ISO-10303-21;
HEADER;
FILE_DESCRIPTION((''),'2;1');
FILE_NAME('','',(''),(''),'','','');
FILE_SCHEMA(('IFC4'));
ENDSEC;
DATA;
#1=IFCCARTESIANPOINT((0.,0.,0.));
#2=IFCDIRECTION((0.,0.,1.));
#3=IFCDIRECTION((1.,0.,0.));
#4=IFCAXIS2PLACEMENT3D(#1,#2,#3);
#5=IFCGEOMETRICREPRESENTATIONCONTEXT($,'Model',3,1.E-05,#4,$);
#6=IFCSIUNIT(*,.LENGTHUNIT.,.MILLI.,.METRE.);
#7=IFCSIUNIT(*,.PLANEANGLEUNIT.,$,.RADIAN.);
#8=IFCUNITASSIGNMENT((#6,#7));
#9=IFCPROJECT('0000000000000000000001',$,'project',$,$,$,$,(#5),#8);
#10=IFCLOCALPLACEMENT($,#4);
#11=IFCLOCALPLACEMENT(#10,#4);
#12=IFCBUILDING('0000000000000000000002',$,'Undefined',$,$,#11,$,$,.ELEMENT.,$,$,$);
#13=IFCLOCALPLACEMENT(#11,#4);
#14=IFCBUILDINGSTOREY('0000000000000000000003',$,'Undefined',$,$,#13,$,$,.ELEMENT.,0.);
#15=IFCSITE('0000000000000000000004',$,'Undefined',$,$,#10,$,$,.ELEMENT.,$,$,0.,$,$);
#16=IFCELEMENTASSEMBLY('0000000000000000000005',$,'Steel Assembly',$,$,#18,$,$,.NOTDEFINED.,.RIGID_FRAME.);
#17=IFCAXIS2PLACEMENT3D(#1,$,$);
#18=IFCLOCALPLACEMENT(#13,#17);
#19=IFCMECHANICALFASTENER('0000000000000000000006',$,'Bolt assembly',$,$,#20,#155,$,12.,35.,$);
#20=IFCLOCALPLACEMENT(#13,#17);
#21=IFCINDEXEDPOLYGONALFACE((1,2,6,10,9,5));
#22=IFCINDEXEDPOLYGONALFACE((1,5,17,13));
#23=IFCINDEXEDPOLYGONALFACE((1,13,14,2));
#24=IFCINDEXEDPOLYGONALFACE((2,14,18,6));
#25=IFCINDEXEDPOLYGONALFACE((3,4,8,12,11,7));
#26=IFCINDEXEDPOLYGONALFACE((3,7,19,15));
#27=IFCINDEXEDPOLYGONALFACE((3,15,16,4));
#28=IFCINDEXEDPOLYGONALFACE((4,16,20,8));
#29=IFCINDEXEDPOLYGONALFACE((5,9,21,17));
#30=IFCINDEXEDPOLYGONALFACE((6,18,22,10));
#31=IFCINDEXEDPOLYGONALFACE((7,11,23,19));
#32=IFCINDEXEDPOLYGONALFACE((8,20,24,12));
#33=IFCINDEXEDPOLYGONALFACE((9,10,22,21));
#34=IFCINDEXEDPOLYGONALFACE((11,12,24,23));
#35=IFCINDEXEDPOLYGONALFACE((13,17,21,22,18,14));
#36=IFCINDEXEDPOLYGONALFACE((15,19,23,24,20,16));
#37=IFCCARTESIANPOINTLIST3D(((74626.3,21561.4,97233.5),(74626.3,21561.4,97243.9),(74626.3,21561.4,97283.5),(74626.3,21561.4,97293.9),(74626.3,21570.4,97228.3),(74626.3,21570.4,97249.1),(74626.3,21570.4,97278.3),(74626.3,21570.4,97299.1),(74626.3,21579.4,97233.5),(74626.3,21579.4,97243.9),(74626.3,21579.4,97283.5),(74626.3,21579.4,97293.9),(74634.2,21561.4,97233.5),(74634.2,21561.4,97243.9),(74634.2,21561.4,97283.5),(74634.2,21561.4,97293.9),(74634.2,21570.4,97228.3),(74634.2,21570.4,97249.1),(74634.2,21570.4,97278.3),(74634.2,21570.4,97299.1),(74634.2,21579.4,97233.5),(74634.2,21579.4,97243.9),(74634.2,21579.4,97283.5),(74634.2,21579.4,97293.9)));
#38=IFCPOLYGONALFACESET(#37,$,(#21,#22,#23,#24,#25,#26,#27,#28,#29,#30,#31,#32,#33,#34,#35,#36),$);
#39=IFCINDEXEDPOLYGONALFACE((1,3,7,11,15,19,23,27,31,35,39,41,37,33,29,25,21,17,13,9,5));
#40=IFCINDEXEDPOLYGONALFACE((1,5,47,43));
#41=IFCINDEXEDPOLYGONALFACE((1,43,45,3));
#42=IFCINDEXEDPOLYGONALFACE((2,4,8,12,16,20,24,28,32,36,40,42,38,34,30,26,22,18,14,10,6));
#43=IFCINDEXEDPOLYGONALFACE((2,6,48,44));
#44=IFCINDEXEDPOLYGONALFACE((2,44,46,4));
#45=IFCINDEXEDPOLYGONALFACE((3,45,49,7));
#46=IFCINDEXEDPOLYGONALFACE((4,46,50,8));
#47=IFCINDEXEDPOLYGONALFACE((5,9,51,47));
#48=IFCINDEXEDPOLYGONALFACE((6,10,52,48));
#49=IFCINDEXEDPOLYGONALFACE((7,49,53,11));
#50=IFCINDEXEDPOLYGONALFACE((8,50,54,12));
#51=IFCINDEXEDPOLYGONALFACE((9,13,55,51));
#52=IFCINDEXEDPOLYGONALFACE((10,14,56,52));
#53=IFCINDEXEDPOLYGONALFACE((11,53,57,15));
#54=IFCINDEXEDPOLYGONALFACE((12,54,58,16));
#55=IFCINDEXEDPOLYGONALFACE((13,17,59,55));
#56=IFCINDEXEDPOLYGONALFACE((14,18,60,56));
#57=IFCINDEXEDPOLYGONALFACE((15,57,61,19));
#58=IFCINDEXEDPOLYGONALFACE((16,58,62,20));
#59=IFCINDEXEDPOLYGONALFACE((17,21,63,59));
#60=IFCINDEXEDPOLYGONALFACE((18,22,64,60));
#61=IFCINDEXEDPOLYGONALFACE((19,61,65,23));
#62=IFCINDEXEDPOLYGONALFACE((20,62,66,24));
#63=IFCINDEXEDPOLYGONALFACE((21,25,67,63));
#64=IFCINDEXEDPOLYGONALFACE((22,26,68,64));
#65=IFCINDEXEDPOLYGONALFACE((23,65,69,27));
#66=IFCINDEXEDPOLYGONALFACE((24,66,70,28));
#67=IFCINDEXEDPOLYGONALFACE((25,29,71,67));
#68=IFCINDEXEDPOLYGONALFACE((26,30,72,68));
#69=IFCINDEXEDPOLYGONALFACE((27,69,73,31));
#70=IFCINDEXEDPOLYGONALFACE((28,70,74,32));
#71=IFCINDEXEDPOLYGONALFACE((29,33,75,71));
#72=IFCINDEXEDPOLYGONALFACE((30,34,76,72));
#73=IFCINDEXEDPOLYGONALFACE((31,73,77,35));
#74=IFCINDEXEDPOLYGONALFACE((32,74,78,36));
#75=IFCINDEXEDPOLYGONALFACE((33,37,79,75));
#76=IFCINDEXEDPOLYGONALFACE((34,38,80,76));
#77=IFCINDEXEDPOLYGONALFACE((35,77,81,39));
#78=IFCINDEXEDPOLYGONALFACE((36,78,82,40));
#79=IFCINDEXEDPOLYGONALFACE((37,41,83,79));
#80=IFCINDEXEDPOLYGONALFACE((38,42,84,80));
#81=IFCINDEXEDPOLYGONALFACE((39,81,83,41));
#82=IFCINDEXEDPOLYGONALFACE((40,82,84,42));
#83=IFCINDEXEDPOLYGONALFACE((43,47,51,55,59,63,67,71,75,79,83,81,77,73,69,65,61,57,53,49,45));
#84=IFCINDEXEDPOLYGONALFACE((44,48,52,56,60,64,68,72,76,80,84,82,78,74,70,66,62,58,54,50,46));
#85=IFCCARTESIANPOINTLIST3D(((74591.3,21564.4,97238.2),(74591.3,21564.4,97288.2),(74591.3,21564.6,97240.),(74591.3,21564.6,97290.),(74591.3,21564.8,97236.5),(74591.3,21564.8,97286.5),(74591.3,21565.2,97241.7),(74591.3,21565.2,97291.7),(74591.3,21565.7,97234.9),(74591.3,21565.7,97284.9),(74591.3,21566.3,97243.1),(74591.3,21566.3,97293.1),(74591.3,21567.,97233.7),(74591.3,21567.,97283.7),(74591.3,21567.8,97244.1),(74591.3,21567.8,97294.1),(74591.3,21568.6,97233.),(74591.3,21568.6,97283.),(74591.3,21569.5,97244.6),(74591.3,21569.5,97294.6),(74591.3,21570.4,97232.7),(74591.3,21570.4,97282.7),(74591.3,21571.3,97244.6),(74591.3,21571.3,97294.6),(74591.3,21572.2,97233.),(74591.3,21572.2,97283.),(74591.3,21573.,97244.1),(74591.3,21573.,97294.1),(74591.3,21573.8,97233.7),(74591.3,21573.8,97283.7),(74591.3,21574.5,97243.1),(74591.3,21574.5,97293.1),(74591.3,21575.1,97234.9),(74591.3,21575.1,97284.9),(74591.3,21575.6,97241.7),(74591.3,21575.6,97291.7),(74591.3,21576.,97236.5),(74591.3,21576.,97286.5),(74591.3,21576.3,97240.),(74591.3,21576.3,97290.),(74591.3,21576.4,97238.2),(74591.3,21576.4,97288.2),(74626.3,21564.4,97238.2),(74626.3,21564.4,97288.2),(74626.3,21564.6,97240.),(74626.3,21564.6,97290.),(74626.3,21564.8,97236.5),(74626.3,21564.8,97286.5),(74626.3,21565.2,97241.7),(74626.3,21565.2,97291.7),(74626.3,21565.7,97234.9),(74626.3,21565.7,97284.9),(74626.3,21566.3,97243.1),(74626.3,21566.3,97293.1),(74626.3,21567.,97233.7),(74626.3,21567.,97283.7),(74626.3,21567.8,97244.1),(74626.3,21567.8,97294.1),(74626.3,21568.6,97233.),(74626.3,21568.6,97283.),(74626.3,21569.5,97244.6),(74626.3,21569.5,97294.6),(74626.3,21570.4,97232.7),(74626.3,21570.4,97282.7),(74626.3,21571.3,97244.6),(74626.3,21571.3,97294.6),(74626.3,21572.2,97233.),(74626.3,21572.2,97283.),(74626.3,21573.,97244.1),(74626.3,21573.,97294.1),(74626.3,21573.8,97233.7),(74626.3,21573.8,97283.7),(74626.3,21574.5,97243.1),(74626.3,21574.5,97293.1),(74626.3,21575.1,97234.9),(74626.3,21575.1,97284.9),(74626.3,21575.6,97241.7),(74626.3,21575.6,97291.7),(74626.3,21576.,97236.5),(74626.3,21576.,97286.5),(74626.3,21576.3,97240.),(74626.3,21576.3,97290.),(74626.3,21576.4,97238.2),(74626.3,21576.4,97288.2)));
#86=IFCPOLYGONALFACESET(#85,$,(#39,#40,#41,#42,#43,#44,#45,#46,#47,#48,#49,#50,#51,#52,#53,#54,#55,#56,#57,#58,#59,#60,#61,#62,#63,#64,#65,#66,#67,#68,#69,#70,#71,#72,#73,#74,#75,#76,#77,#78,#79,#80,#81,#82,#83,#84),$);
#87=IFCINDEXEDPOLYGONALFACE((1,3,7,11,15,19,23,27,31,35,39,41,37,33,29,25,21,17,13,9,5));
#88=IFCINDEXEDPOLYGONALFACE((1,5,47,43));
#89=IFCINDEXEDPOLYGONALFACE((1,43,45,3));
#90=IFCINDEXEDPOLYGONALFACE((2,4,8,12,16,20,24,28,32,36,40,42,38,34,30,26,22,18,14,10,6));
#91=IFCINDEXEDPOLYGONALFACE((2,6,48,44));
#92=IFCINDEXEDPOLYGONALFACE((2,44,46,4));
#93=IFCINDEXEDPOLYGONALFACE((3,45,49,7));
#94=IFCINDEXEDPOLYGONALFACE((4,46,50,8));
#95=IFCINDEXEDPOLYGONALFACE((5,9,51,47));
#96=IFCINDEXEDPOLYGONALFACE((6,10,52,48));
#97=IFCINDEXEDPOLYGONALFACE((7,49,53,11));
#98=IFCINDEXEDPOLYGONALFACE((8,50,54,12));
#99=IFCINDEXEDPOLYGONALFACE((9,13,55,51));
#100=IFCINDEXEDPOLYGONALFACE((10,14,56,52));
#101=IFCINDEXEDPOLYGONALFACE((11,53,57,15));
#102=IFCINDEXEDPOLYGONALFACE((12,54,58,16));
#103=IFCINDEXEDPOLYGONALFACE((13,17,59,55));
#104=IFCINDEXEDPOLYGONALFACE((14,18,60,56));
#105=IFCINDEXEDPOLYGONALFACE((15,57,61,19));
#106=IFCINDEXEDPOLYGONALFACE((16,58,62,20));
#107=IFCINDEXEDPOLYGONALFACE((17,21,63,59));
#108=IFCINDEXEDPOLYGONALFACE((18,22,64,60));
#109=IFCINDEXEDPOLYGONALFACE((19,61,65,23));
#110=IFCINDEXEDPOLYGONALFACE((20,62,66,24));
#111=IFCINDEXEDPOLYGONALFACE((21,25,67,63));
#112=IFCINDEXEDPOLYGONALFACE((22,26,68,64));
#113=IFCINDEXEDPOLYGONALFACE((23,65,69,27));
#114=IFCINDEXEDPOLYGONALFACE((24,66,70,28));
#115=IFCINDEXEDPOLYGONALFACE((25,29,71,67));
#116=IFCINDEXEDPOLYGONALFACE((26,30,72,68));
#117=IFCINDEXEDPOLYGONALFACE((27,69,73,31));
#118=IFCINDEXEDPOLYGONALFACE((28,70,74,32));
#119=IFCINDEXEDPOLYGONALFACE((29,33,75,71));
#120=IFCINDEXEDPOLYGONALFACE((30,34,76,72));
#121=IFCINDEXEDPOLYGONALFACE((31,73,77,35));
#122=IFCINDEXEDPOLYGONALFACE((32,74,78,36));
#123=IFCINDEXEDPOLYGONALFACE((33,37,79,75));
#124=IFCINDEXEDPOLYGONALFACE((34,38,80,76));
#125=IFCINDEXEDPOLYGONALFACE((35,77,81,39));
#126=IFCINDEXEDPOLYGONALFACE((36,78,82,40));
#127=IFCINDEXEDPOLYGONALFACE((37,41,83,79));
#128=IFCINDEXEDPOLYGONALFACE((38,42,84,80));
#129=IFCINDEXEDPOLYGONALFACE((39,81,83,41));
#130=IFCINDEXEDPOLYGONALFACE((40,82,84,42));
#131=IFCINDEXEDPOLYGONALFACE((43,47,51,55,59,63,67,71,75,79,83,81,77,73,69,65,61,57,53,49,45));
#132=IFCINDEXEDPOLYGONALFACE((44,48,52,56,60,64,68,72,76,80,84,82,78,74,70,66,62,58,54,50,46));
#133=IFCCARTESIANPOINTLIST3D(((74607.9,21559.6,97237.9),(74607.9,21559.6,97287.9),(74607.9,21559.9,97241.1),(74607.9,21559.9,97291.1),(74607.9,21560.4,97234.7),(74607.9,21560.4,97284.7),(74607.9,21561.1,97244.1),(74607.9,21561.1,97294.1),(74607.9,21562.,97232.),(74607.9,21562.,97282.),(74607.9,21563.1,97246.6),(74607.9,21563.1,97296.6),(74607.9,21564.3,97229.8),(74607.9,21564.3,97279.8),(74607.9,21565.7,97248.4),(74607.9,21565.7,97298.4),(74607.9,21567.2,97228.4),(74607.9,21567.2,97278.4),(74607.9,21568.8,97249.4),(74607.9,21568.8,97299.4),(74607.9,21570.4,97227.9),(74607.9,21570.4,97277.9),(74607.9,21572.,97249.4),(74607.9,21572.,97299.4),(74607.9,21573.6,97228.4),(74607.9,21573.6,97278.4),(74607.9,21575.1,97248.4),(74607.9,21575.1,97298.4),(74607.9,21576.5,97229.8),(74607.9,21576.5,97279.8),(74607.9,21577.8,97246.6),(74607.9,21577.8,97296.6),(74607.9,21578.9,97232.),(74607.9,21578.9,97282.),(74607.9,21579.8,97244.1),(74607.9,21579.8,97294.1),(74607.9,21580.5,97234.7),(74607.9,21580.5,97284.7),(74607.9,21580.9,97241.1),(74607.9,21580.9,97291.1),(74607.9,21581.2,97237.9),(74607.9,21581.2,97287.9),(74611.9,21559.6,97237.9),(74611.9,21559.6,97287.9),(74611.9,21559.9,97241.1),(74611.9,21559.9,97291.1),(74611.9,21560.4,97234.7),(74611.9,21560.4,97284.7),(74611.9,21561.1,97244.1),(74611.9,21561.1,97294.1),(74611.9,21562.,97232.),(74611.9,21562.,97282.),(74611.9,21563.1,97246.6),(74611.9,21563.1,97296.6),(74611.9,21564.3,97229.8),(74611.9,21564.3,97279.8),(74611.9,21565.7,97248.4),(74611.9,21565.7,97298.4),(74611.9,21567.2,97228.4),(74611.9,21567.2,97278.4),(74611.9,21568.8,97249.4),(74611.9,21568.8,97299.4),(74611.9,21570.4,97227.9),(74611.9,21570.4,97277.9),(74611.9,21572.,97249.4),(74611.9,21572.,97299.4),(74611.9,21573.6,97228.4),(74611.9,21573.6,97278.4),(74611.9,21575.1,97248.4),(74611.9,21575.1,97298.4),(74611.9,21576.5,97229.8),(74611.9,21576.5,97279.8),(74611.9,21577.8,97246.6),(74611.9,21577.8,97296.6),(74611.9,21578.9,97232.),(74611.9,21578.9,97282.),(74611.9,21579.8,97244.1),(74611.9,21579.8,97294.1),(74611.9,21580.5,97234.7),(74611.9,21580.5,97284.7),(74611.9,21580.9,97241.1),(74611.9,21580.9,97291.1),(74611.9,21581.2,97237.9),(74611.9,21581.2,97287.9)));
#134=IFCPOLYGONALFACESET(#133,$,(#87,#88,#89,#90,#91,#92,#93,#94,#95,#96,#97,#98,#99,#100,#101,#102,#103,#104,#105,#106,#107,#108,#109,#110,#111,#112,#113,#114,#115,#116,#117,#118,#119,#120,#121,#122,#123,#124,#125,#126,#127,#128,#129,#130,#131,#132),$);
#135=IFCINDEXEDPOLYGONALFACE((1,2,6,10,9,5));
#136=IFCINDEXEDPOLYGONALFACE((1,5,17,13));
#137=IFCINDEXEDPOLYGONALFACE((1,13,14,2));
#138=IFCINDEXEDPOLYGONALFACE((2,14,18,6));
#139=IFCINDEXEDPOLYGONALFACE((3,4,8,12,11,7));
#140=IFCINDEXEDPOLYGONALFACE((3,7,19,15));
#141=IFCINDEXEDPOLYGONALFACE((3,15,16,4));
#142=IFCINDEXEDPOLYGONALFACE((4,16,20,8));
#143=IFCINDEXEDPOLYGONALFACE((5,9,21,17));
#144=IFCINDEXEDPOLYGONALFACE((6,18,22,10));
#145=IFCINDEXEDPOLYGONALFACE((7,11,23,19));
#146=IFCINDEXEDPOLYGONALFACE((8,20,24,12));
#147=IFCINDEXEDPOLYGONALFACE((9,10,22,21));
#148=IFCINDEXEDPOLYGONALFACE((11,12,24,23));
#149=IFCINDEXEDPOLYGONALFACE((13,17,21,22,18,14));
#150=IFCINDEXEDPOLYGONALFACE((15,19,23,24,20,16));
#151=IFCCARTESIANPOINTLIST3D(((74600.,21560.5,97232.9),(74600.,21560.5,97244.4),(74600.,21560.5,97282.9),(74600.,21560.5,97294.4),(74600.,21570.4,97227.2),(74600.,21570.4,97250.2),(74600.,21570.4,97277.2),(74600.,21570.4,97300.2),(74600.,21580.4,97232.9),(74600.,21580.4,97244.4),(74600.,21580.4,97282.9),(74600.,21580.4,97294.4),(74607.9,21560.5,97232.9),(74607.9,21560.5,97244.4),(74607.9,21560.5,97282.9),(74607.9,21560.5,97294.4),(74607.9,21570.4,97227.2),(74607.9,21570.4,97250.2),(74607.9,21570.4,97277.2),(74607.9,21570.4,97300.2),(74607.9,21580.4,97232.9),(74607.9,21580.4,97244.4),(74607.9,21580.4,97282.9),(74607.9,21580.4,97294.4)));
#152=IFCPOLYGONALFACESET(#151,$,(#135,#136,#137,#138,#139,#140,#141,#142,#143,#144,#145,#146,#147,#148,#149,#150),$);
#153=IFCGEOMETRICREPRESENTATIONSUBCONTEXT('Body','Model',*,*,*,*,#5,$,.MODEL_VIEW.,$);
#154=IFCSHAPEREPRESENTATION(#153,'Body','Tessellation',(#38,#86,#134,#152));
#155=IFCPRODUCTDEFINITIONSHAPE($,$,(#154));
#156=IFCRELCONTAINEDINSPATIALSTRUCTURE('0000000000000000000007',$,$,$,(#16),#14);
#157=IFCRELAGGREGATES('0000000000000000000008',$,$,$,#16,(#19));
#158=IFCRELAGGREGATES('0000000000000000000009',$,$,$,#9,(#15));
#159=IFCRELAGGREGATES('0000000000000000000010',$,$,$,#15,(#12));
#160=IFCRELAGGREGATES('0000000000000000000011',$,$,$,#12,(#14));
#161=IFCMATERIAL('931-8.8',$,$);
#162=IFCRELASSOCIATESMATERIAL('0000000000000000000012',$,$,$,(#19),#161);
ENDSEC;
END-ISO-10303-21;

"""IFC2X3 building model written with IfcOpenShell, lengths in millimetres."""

from ifc_helpers import new_model, si_unit, frame, origin_with_axes, origin_2d_with_axis, place, context, subcontext, project, spatial, polyline, circle, outline, extrude, source, transform, mapped, material, element, aggregate, save


model = new_model("IFC2X3")

# Units and contexts
model_context = context("Model", 3, precision=1e-05, world=origin_with_axes())
body_context = subcontext(model_context, "Body", "Model", "MODEL_VIEW")
ifc_project = project(units=[si_unit("LENGTHUNIT", "METRE", prefix="MILLI"), si_unit("PLANEANGLEUNIT", "RADIAN")], contexts=[model_context])

# Site, building, storey
site_placement = place(None, origin_with_axes())
site = spatial("IfcSite", under=ifc_project, at=site_placement, Name="Undefined", CompositionType="ELEMENT", RefElevation=0.0)
building_placement = place(site_placement, origin_with_axes())
building = spatial("IfcBuilding", under=site, at=building_placement, Name="Undefined", CompositionType="ELEMENT")
storey_placement = place(building_placement, origin_with_axes())
storey = spatial("IfcBuildingStorey", under=building, at=storey_placement, Name="Undefined", CompositionType="ELEMENT", Elevation=0.0)

# Shared definitions
ifc_material_1 = material(Name="931-8.8")

# Element assembly, mechanical fastener
shared_shape_1 = source(origin_with_axes(), body_context, "Body", "SweptSolid", [
    extrude(outline(polyline([(10.4, 0.0), (5.2, 9.0), (-5.2, 9.0), (-10.4, 0.0), (-5.2, -9.0), (5.2, -9.0), (10.4, 0.0)])), frame((0.0, -22.3, 0.0), z_axis=(0.0, 1.0, 0.0), x_axis=(1.0, 0.0, 0.0)), (0.0, 0.0, 1.0), 7.9),
    extrude(circle(Radius=6.0, at=origin_2d_with_axis()), frame((0.0, -14.4, 0.0), z_axis=(0.0, 1.0, 0.0), x_axis=(1.0, 0.0, 0.0)), (0.0, 0.0, 1.0), 35.0),
    extrude(circle(Radius=10.8, at=origin_2d_with_axis()), frame((0.0, 0.0, 0.0), z_axis=(0.0, 1.0, 0.0), x_axis=(1.0, 0.0, 0.0)), (0.0, 0.0, 1.0), 4.0),
    extrude(outline(polyline([(11.5, 0.0), (5.8, 10.0), (-5.8, 10.0), (-11.5, 0.0), (-5.8, -10.0), (5.8, -10.0), (11.5, 0.0)])), frame((0.0, 4.0, 0.0), z_axis=(0.0, 1.0, 0.0), x_axis=(1.0, 0.0, 0.0)), (0.0, 0.0, 1.0), 7.9),
])
assembly_1_placement = place(storey_placement, origin_with_axes())
assembly_1 = element("IfcElementAssembly", 1, at=assembly_1_placement, inside=storey, Name="Steel Assembly", AssemblyPlace="NOTDEFINED", PredefinedType="RIGID_FRAME")
mechanical_fastener_1_placement = place(assembly_1_placement, frame((74611.9, 21570.4, 97288.7), z_axis=(0.0, 1.0, 0.0), x_axis=(0.0, 0.0, -1.0)))
mechanical_fastener_1 = element("IfcMechanicalFastener", 2, at=mechanical_fastener_1_placement, material=ifc_material_1, Name="Bolt assembly", NominalDiameter=12.0, NominalLength=35.0, context=body_context, shape_type="MappedRepresentation", body=[
    mapped(shared_shape_1, transform((0.0, 0.0, 0.0))),
    mapped(shared_shape_1, transform((50.0, 0.0, 0.0))),
])

aggregate(assembly_1, [mechanical_fastener_1])

save(model, "model.ifc")
